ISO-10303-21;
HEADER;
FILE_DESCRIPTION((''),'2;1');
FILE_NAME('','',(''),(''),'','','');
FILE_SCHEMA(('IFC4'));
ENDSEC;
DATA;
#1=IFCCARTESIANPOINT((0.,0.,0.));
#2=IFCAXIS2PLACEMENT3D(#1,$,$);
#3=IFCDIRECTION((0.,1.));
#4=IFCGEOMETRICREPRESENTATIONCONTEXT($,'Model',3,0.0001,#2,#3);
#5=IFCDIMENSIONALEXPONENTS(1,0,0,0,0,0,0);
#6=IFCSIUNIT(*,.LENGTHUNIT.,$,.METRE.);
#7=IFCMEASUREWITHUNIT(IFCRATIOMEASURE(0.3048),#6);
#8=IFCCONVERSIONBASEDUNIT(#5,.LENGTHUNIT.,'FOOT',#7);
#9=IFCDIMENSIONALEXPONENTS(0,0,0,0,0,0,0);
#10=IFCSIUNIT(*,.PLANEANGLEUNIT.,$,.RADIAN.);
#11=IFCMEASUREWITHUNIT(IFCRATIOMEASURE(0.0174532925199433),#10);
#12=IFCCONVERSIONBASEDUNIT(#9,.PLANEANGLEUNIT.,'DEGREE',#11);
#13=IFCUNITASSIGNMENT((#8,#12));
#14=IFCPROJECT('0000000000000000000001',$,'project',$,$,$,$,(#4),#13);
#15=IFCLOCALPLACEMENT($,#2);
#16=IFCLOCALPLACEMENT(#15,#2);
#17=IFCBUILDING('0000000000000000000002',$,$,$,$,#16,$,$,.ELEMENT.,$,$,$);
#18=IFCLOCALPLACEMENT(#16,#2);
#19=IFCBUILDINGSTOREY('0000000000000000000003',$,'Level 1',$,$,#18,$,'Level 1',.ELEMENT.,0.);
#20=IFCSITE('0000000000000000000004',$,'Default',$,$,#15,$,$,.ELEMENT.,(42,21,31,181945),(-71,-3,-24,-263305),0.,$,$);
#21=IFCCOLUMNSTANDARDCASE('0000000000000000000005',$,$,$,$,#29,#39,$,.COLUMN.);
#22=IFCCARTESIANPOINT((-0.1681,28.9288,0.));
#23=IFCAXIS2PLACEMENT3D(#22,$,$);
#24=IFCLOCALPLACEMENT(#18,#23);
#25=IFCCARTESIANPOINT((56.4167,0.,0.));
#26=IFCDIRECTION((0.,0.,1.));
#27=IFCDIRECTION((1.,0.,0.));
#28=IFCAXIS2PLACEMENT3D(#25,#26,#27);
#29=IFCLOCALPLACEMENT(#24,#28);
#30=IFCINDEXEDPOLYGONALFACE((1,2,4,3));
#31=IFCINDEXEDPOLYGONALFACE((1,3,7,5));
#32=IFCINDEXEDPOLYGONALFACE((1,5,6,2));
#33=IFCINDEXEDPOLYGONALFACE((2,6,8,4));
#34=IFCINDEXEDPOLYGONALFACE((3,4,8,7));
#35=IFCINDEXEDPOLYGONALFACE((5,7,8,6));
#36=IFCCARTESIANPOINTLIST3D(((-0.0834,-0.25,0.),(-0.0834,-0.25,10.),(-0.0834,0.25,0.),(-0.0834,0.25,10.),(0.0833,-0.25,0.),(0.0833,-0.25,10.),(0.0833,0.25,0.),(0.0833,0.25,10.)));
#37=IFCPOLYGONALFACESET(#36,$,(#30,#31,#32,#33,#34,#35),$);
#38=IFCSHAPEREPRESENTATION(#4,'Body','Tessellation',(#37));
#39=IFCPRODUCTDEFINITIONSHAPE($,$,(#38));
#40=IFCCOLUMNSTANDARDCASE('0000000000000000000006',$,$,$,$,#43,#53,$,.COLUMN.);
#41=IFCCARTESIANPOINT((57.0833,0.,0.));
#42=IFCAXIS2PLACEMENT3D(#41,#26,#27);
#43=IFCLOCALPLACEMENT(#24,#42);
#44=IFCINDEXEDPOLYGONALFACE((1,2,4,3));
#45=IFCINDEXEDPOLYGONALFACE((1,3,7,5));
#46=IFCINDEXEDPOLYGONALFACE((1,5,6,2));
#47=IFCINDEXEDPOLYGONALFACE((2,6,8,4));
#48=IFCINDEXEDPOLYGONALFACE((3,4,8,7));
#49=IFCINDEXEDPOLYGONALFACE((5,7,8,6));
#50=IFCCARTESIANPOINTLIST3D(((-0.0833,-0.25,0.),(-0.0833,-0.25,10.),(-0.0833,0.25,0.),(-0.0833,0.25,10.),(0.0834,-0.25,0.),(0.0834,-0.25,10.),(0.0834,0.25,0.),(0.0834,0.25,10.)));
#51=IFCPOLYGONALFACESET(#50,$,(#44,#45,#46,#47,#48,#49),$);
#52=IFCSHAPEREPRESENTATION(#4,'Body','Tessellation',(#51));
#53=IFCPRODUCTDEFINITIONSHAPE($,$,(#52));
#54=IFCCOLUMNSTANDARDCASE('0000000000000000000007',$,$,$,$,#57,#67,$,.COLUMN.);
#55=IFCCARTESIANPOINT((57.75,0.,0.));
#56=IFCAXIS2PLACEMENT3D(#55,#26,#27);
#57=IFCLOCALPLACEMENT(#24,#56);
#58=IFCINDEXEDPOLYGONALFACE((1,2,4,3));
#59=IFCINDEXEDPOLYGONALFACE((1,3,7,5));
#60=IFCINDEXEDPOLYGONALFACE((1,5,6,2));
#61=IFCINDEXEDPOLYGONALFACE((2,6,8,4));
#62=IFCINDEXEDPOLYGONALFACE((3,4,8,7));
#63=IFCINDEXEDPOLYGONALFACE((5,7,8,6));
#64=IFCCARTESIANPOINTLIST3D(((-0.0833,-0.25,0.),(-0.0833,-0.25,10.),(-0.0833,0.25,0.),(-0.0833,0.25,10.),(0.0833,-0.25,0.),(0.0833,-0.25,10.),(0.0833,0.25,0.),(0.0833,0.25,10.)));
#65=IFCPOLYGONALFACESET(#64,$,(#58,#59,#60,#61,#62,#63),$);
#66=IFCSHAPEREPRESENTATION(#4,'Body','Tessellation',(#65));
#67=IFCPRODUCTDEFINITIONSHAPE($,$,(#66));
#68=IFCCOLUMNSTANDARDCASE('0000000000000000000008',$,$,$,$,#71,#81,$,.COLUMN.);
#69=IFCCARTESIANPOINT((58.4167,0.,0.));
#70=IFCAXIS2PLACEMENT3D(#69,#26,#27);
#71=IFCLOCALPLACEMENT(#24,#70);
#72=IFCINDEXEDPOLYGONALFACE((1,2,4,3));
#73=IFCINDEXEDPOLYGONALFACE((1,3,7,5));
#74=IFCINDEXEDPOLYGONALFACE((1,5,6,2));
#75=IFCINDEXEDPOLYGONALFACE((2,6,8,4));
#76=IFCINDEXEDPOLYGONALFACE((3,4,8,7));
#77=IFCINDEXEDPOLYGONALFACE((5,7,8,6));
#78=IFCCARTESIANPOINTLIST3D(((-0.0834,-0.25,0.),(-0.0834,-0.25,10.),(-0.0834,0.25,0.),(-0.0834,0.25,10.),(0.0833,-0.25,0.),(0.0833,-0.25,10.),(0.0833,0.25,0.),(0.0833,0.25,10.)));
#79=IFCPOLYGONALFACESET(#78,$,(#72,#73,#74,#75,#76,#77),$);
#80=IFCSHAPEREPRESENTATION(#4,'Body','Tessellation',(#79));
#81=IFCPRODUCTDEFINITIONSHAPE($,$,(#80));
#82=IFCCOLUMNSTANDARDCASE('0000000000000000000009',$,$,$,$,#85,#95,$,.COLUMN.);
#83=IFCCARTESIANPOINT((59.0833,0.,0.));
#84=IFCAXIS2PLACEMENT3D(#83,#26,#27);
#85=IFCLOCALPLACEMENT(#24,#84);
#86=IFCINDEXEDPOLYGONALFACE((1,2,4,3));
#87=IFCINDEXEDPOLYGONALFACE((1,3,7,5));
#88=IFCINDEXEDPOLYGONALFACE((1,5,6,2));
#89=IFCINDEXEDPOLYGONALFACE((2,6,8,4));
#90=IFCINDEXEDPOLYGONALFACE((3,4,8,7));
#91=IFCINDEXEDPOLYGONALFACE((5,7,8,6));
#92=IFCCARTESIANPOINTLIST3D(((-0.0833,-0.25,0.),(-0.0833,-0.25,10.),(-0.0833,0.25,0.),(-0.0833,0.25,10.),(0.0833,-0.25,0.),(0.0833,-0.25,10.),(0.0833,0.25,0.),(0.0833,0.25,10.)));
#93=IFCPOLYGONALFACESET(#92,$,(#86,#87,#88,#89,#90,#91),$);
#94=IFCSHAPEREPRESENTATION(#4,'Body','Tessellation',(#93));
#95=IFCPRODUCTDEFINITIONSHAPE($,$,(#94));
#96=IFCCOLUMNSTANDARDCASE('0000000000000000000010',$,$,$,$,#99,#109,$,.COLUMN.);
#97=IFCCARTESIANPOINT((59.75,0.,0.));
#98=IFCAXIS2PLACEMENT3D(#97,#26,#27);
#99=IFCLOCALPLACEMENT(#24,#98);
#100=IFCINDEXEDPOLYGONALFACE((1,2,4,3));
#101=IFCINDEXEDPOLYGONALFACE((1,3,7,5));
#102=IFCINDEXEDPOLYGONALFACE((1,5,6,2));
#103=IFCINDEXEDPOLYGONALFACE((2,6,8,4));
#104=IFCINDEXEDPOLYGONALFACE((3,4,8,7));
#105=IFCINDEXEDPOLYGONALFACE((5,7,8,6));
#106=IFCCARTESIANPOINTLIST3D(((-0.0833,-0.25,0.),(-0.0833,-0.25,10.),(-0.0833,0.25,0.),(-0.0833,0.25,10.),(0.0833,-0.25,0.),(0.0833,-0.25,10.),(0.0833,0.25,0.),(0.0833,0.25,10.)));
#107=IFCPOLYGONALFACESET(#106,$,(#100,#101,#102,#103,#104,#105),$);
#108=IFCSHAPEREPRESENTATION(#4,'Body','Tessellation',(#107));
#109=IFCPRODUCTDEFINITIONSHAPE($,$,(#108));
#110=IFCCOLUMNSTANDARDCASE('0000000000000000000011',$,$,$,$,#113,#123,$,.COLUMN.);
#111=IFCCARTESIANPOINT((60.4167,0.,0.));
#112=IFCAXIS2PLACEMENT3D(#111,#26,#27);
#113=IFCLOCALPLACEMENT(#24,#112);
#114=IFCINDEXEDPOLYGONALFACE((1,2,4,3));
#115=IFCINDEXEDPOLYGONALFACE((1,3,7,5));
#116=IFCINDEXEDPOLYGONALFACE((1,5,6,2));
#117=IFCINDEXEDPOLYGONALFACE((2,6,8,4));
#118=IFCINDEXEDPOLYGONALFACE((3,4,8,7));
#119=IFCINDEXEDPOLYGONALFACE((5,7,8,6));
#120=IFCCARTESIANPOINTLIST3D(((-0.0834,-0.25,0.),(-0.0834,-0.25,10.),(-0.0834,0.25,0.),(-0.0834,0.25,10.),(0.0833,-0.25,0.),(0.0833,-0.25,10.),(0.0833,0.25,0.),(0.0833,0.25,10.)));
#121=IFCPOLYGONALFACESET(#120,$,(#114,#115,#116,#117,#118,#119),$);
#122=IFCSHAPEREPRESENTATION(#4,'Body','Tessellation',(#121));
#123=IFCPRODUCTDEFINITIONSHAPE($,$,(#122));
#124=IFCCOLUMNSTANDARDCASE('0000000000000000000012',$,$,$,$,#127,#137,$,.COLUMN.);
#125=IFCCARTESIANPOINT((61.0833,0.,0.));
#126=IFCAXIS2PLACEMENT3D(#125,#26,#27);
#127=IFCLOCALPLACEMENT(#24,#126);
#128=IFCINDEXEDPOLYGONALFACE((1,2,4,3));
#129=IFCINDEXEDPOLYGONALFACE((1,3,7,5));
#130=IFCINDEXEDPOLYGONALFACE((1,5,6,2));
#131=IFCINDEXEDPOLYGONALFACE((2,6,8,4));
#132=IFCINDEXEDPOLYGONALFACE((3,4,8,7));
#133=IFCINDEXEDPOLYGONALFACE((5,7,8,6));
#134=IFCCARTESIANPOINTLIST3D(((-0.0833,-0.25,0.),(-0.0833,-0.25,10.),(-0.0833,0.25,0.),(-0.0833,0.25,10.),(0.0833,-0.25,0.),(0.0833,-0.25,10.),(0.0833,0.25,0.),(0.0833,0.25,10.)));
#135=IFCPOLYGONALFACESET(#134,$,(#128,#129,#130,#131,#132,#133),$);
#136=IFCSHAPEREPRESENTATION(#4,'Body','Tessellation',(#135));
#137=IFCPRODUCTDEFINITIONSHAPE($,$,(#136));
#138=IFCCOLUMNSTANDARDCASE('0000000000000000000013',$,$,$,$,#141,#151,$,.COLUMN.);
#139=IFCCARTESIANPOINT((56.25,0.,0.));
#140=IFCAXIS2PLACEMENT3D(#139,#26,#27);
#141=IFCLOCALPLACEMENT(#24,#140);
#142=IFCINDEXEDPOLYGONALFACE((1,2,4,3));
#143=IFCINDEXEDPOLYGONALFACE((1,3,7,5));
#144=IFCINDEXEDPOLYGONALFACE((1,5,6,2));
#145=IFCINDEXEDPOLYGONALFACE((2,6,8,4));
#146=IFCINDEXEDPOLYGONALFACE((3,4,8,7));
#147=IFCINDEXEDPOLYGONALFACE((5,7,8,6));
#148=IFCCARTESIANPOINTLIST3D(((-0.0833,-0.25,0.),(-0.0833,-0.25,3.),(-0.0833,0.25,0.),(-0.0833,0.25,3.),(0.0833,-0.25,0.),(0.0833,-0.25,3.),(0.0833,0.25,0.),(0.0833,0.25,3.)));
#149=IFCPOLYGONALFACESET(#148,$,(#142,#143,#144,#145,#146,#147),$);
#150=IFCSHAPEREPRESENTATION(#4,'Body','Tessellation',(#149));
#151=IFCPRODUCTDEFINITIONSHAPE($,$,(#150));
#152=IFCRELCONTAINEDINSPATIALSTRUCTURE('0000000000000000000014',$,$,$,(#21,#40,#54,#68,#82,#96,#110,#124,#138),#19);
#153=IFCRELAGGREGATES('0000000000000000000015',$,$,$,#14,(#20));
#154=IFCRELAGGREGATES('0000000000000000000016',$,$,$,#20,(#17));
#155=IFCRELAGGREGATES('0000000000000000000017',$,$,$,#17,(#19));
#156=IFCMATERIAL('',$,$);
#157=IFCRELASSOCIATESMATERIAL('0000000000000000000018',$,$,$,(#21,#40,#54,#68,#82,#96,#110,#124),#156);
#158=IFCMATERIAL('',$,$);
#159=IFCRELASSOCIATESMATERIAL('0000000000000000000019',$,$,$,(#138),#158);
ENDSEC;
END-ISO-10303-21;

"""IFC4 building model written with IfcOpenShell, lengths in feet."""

from ifc_helpers import new_model, entity, si_unit, converted_unit, direction, frame, origin, place, context, project, spatial, rectangle, extrude, material, element, save


model = new_model("IFC4")

# Units and contexts
model_context = context("Model", 3, precision=0.0001, world=origin(), true_north=direction((0.0, 1.0)))
ifc_project = project(units=[converted_unit("LENGTHUNIT", "FOOT", entity("IfcRatioMeasure", 0.3048), si_unit("LENGTHUNIT", "METRE"), dimensions=[1, 0, 0, 0, 0, 0, 0]), converted_unit("PLANEANGLEUNIT", "DEGREE", entity("IfcRatioMeasure", 0.0174532925199433), si_unit("PLANEANGLEUNIT", "RADIAN"), dimensions=[0, 0, 0, 0, 0, 0, 0])], contexts=[model_context])

# Site, building, storey
site_placement = place(None, origin())
site = spatial("IfcSite", under=ifc_project, at=site_placement, Name="Default", CompositionType="ELEMENT", RefLatitude=(42, 21, 31, 181945), RefLongitude=(-71, -3, -24, -263305), RefElevation=0.0)
building_placement = place(site_placement, origin())
building = spatial("IfcBuilding", under=site, at=building_placement, CompositionType="ELEMENT")
storey_placement = place(building_placement, origin())
storey = spatial("IfcBuildingStorey", under=building, at=storey_placement, Name="Level 1", LongName="Level 1", CompositionType="ELEMENT", Elevation=0.0)

# Columns
ifc_material_1 = material(Name="")
placement = place(storey_placement, frame((-0.1681, 28.9288, 0.0)))
for number, where, z_axis, x_axis in (
    (1, (56.4167, 0.0, 0.0), (0.0, 0.0, 1.0), (1.0, 0.0, 0.0)),
    (2, (57.0833, 0.0, 0.0), (0.0, 0.0, 1.0), (1.0, 0.0, 0.0)),
    (3, (57.75, 0.0, 0.0), (0.0, 0.0, 1.0), (1.0, 0.0, 0.0)),
    (4, (58.4167, 0.0, 0.0), (0.0, 0.0, 1.0), (1.0, 0.0, 0.0)),
    (5, (59.0833, 0.0, 0.0), (0.0, 0.0, 1.0), (1.0, 0.0, 0.0)),
    (6, (59.75, 0.0, 0.0), (0.0, 0.0, 1.0), (1.0, 0.0, 0.0)),
    (7, (60.4167, 0.0, 0.0), (0.0, 0.0, 1.0), (1.0, 0.0, 0.0)),
    (8, (61.0833, 0.0, 0.0), (0.0, 0.0, 1.0), (1.0, 0.0, 0.0)),
):
    element("IfcColumnStandardCase", number, at=place(placement, frame(where, z_axis=z_axis, x_axis=x_axis)), inside=storey, material=ifc_material_1, PredefinedType="COLUMN", context=model_context, shape_type="SweptSolid", body=[
        extrude(rectangle(XDim=0.1667, YDim=0.5), origin(), (0.0, 0.0, 1.0), 10.0),
    ])
ifc_material_2 = material(Name="")
for number, where, z_axis, x_axis in (
    (9, (56.25, 0.0, 0.0), (0.0, 0.0, 1.0), (1.0, 0.0, 0.0)),
):
    element("IfcColumnStandardCase", number, at=place(placement, frame(where, z_axis=z_axis, x_axis=x_axis)), inside=storey, material=ifc_material_2, PredefinedType="COLUMN", context=model_context, shape_type="SweptSolid", body=[
        extrude(rectangle(XDim=0.1667, YDim=0.5), origin(), (0.0, 0.0, 1.0), 3.0),
    ])

save(model, "model.ifc")
